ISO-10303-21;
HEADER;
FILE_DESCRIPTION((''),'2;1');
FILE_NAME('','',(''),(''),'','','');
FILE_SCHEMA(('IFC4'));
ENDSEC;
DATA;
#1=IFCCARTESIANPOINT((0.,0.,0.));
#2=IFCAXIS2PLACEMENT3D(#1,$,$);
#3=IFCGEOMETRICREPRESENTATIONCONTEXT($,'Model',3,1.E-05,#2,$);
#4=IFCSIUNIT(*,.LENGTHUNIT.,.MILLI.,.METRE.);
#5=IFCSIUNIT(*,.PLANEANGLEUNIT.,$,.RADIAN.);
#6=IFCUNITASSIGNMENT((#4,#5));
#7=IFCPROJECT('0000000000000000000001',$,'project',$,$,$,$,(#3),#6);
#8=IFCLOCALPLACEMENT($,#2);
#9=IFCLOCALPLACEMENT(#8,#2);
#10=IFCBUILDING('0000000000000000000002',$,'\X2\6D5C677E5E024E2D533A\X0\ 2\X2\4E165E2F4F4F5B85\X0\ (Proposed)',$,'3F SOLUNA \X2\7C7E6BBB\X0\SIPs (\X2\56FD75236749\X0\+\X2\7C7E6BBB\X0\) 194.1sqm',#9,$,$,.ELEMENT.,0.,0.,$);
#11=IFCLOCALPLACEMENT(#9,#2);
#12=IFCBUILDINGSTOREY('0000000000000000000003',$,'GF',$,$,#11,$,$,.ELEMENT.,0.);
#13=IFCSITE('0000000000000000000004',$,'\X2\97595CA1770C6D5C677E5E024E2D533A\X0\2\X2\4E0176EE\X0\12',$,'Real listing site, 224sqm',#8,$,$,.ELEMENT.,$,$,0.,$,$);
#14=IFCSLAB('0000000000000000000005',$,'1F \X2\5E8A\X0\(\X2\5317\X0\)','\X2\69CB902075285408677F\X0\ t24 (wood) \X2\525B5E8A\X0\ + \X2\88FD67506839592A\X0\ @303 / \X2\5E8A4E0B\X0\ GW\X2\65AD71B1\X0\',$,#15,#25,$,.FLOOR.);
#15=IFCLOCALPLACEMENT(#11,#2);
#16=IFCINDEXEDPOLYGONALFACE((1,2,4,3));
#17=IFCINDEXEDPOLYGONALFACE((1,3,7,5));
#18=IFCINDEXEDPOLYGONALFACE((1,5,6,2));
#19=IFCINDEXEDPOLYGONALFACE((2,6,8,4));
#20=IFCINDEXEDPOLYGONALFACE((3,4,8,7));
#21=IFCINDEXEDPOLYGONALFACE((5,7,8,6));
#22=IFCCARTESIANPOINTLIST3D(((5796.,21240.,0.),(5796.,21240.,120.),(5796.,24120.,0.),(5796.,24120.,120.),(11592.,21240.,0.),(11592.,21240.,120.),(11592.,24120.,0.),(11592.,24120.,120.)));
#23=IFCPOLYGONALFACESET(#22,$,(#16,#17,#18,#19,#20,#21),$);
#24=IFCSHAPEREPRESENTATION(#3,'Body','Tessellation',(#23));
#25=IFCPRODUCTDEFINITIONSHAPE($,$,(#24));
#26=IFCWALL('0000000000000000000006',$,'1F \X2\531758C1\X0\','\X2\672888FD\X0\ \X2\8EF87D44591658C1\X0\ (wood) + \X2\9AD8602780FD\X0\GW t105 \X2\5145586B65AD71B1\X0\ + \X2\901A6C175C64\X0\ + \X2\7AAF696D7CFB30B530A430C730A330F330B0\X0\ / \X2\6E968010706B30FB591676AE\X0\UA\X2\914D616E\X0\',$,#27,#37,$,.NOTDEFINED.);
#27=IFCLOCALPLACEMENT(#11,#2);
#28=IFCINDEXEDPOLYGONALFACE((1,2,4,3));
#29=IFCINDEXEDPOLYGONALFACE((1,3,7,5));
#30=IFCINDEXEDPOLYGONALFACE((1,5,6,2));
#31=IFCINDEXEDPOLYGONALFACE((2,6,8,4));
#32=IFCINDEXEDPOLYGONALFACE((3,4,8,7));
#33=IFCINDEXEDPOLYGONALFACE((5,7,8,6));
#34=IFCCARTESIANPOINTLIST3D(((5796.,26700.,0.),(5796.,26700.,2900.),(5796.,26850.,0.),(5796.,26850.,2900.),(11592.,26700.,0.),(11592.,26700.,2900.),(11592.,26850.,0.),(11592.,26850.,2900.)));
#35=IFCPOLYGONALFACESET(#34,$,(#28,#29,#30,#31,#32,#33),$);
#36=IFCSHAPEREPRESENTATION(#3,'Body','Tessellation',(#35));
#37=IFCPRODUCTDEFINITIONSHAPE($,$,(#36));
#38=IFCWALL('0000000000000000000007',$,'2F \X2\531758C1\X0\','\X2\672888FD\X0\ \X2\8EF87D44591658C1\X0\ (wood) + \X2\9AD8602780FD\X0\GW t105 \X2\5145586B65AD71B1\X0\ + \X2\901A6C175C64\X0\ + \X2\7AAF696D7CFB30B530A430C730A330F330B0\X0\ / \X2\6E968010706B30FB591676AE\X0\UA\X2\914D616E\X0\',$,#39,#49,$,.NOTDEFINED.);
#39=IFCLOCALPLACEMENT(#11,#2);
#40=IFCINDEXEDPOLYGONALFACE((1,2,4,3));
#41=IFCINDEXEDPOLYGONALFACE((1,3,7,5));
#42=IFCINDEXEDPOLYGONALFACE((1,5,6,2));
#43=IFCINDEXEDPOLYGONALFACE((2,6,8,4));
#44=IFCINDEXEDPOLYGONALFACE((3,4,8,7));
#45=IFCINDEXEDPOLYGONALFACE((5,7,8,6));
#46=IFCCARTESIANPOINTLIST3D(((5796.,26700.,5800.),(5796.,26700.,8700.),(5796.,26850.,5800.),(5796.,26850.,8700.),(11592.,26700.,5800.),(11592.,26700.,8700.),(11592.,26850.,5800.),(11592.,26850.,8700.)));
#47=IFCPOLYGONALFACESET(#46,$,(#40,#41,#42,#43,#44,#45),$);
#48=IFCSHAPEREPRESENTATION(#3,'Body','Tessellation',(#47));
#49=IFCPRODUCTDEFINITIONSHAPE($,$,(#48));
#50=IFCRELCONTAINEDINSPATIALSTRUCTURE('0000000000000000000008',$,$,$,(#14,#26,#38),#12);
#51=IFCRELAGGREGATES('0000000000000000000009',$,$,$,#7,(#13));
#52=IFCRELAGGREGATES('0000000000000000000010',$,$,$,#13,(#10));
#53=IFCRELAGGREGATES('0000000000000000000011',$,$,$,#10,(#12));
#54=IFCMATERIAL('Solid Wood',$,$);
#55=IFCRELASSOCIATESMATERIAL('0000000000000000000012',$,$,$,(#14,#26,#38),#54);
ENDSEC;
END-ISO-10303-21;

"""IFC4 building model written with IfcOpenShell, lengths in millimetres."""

from ifc_helpers import new_model, si_unit, frame, frame_2d, origin, place, context, project, spatial, rectangle, extrude, material, element, save


model = new_model("IFC4")

# Units and contexts
model_context = context("Model", 3, precision=1e-05, world=origin())
ifc_project = project(units=[si_unit("LENGTHUNIT", "METRE", prefix="MILLI"), si_unit("PLANEANGLEUNIT", "RADIAN")], contexts=[model_context])

# Site, building, storey
site_placement = place(None, origin())
site = spatial("IfcSite", under=ifc_project, at=site_placement, Name="静岡県浜松市中区2丁目12", ObjectType="Real listing site, 224sqm", CompositionType="ELEMENT", RefElevation=0.0)
building_placement = place(site_placement, origin())
building = spatial("IfcBuilding", under=site, at=building_placement, Name="浜松市中区 2世帯住宅 (Proposed)", ObjectType="3F SOLUNA 籾殻SIPs (国産杉+籾殻) 194.1sqm", CompositionType="ELEMENT", ElevationOfRefHeight=0.0, ElevationOfTerrain=0.0)
storey_placement = place(building_placement, origin())
storey = spatial("IfcBuildingStorey", under=building, at=storey_placement, Name="GF", CompositionType="ELEMENT", Elevation=0.0)

# Slab
ifc_material_1 = material(Name="Solid Wood")
slab_1_placement = place(storey_placement, frame((2898.0, 10620.0, 0.0)))
element("IfcSlab", 1, at=slab_1_placement, inside=storey, material=ifc_material_1, Name="1F 床(北)", Description="構造用合板 t24 (wood) 剛床 + 製材根太 @303 / 床下 GW断熱", PredefinedType="FLOOR", context=model_context, shape_type="SweptSolid", body=[
    extrude(rectangle(XDim=5796.0, YDim=2880.0, at=frame_2d((2898.0, 1440.0))), frame((2898.0, 10620.0, 0.0)), (0.0, 0.0, 1.0), 120.0),
])

# Wall
wall_1_placement = place(storey_placement, frame((2898.0, 13350.0, 0.0)))
element("IfcWall", 2, at=wall_1_placement, inside=storey, material=ifc_material_1, Name="1F 北壁", Description="木製 軸組外壁 (wood) + 高性能GW t105 充填断熱 + 通気層 + 窯業系サイディング / 準耐火・外皮UA配慮", PredefinedType="NOTDEFINED", context=model_context, shape_type="SweptSolid", body=[
    extrude(rectangle(XDim=5796.0, YDim=150.0, at=frame_2d((2898.0, 75.0))), frame((2898.0, 13350.0, 0.0)), (0.0, 0.0, 1.0), 2900.0),
])

# Wall
wall_2_placement = place(storey_placement, frame((2898.0, 13350.0, 2900.0)))
element("IfcWall", 3, at=wall_2_placement, inside=storey, material=ifc_material_1, Name="2F 北壁", Description="木製 軸組外壁 (wood) + 高性能GW t105 充填断熱 + 通気層 + 窯業系サイディング / 準耐火・外皮UA配慮", PredefinedType="NOTDEFINED", context=model_context, shape_type="SweptSolid", body=[
    extrude(rectangle(XDim=5796.0, YDim=150.0, at=frame_2d((2898.0, 75.0))), frame((2898.0, 13350.0, 2900.0)), (0.0, 0.0, 1.0), 2900.0),
])

save(model, "model.ifc")
